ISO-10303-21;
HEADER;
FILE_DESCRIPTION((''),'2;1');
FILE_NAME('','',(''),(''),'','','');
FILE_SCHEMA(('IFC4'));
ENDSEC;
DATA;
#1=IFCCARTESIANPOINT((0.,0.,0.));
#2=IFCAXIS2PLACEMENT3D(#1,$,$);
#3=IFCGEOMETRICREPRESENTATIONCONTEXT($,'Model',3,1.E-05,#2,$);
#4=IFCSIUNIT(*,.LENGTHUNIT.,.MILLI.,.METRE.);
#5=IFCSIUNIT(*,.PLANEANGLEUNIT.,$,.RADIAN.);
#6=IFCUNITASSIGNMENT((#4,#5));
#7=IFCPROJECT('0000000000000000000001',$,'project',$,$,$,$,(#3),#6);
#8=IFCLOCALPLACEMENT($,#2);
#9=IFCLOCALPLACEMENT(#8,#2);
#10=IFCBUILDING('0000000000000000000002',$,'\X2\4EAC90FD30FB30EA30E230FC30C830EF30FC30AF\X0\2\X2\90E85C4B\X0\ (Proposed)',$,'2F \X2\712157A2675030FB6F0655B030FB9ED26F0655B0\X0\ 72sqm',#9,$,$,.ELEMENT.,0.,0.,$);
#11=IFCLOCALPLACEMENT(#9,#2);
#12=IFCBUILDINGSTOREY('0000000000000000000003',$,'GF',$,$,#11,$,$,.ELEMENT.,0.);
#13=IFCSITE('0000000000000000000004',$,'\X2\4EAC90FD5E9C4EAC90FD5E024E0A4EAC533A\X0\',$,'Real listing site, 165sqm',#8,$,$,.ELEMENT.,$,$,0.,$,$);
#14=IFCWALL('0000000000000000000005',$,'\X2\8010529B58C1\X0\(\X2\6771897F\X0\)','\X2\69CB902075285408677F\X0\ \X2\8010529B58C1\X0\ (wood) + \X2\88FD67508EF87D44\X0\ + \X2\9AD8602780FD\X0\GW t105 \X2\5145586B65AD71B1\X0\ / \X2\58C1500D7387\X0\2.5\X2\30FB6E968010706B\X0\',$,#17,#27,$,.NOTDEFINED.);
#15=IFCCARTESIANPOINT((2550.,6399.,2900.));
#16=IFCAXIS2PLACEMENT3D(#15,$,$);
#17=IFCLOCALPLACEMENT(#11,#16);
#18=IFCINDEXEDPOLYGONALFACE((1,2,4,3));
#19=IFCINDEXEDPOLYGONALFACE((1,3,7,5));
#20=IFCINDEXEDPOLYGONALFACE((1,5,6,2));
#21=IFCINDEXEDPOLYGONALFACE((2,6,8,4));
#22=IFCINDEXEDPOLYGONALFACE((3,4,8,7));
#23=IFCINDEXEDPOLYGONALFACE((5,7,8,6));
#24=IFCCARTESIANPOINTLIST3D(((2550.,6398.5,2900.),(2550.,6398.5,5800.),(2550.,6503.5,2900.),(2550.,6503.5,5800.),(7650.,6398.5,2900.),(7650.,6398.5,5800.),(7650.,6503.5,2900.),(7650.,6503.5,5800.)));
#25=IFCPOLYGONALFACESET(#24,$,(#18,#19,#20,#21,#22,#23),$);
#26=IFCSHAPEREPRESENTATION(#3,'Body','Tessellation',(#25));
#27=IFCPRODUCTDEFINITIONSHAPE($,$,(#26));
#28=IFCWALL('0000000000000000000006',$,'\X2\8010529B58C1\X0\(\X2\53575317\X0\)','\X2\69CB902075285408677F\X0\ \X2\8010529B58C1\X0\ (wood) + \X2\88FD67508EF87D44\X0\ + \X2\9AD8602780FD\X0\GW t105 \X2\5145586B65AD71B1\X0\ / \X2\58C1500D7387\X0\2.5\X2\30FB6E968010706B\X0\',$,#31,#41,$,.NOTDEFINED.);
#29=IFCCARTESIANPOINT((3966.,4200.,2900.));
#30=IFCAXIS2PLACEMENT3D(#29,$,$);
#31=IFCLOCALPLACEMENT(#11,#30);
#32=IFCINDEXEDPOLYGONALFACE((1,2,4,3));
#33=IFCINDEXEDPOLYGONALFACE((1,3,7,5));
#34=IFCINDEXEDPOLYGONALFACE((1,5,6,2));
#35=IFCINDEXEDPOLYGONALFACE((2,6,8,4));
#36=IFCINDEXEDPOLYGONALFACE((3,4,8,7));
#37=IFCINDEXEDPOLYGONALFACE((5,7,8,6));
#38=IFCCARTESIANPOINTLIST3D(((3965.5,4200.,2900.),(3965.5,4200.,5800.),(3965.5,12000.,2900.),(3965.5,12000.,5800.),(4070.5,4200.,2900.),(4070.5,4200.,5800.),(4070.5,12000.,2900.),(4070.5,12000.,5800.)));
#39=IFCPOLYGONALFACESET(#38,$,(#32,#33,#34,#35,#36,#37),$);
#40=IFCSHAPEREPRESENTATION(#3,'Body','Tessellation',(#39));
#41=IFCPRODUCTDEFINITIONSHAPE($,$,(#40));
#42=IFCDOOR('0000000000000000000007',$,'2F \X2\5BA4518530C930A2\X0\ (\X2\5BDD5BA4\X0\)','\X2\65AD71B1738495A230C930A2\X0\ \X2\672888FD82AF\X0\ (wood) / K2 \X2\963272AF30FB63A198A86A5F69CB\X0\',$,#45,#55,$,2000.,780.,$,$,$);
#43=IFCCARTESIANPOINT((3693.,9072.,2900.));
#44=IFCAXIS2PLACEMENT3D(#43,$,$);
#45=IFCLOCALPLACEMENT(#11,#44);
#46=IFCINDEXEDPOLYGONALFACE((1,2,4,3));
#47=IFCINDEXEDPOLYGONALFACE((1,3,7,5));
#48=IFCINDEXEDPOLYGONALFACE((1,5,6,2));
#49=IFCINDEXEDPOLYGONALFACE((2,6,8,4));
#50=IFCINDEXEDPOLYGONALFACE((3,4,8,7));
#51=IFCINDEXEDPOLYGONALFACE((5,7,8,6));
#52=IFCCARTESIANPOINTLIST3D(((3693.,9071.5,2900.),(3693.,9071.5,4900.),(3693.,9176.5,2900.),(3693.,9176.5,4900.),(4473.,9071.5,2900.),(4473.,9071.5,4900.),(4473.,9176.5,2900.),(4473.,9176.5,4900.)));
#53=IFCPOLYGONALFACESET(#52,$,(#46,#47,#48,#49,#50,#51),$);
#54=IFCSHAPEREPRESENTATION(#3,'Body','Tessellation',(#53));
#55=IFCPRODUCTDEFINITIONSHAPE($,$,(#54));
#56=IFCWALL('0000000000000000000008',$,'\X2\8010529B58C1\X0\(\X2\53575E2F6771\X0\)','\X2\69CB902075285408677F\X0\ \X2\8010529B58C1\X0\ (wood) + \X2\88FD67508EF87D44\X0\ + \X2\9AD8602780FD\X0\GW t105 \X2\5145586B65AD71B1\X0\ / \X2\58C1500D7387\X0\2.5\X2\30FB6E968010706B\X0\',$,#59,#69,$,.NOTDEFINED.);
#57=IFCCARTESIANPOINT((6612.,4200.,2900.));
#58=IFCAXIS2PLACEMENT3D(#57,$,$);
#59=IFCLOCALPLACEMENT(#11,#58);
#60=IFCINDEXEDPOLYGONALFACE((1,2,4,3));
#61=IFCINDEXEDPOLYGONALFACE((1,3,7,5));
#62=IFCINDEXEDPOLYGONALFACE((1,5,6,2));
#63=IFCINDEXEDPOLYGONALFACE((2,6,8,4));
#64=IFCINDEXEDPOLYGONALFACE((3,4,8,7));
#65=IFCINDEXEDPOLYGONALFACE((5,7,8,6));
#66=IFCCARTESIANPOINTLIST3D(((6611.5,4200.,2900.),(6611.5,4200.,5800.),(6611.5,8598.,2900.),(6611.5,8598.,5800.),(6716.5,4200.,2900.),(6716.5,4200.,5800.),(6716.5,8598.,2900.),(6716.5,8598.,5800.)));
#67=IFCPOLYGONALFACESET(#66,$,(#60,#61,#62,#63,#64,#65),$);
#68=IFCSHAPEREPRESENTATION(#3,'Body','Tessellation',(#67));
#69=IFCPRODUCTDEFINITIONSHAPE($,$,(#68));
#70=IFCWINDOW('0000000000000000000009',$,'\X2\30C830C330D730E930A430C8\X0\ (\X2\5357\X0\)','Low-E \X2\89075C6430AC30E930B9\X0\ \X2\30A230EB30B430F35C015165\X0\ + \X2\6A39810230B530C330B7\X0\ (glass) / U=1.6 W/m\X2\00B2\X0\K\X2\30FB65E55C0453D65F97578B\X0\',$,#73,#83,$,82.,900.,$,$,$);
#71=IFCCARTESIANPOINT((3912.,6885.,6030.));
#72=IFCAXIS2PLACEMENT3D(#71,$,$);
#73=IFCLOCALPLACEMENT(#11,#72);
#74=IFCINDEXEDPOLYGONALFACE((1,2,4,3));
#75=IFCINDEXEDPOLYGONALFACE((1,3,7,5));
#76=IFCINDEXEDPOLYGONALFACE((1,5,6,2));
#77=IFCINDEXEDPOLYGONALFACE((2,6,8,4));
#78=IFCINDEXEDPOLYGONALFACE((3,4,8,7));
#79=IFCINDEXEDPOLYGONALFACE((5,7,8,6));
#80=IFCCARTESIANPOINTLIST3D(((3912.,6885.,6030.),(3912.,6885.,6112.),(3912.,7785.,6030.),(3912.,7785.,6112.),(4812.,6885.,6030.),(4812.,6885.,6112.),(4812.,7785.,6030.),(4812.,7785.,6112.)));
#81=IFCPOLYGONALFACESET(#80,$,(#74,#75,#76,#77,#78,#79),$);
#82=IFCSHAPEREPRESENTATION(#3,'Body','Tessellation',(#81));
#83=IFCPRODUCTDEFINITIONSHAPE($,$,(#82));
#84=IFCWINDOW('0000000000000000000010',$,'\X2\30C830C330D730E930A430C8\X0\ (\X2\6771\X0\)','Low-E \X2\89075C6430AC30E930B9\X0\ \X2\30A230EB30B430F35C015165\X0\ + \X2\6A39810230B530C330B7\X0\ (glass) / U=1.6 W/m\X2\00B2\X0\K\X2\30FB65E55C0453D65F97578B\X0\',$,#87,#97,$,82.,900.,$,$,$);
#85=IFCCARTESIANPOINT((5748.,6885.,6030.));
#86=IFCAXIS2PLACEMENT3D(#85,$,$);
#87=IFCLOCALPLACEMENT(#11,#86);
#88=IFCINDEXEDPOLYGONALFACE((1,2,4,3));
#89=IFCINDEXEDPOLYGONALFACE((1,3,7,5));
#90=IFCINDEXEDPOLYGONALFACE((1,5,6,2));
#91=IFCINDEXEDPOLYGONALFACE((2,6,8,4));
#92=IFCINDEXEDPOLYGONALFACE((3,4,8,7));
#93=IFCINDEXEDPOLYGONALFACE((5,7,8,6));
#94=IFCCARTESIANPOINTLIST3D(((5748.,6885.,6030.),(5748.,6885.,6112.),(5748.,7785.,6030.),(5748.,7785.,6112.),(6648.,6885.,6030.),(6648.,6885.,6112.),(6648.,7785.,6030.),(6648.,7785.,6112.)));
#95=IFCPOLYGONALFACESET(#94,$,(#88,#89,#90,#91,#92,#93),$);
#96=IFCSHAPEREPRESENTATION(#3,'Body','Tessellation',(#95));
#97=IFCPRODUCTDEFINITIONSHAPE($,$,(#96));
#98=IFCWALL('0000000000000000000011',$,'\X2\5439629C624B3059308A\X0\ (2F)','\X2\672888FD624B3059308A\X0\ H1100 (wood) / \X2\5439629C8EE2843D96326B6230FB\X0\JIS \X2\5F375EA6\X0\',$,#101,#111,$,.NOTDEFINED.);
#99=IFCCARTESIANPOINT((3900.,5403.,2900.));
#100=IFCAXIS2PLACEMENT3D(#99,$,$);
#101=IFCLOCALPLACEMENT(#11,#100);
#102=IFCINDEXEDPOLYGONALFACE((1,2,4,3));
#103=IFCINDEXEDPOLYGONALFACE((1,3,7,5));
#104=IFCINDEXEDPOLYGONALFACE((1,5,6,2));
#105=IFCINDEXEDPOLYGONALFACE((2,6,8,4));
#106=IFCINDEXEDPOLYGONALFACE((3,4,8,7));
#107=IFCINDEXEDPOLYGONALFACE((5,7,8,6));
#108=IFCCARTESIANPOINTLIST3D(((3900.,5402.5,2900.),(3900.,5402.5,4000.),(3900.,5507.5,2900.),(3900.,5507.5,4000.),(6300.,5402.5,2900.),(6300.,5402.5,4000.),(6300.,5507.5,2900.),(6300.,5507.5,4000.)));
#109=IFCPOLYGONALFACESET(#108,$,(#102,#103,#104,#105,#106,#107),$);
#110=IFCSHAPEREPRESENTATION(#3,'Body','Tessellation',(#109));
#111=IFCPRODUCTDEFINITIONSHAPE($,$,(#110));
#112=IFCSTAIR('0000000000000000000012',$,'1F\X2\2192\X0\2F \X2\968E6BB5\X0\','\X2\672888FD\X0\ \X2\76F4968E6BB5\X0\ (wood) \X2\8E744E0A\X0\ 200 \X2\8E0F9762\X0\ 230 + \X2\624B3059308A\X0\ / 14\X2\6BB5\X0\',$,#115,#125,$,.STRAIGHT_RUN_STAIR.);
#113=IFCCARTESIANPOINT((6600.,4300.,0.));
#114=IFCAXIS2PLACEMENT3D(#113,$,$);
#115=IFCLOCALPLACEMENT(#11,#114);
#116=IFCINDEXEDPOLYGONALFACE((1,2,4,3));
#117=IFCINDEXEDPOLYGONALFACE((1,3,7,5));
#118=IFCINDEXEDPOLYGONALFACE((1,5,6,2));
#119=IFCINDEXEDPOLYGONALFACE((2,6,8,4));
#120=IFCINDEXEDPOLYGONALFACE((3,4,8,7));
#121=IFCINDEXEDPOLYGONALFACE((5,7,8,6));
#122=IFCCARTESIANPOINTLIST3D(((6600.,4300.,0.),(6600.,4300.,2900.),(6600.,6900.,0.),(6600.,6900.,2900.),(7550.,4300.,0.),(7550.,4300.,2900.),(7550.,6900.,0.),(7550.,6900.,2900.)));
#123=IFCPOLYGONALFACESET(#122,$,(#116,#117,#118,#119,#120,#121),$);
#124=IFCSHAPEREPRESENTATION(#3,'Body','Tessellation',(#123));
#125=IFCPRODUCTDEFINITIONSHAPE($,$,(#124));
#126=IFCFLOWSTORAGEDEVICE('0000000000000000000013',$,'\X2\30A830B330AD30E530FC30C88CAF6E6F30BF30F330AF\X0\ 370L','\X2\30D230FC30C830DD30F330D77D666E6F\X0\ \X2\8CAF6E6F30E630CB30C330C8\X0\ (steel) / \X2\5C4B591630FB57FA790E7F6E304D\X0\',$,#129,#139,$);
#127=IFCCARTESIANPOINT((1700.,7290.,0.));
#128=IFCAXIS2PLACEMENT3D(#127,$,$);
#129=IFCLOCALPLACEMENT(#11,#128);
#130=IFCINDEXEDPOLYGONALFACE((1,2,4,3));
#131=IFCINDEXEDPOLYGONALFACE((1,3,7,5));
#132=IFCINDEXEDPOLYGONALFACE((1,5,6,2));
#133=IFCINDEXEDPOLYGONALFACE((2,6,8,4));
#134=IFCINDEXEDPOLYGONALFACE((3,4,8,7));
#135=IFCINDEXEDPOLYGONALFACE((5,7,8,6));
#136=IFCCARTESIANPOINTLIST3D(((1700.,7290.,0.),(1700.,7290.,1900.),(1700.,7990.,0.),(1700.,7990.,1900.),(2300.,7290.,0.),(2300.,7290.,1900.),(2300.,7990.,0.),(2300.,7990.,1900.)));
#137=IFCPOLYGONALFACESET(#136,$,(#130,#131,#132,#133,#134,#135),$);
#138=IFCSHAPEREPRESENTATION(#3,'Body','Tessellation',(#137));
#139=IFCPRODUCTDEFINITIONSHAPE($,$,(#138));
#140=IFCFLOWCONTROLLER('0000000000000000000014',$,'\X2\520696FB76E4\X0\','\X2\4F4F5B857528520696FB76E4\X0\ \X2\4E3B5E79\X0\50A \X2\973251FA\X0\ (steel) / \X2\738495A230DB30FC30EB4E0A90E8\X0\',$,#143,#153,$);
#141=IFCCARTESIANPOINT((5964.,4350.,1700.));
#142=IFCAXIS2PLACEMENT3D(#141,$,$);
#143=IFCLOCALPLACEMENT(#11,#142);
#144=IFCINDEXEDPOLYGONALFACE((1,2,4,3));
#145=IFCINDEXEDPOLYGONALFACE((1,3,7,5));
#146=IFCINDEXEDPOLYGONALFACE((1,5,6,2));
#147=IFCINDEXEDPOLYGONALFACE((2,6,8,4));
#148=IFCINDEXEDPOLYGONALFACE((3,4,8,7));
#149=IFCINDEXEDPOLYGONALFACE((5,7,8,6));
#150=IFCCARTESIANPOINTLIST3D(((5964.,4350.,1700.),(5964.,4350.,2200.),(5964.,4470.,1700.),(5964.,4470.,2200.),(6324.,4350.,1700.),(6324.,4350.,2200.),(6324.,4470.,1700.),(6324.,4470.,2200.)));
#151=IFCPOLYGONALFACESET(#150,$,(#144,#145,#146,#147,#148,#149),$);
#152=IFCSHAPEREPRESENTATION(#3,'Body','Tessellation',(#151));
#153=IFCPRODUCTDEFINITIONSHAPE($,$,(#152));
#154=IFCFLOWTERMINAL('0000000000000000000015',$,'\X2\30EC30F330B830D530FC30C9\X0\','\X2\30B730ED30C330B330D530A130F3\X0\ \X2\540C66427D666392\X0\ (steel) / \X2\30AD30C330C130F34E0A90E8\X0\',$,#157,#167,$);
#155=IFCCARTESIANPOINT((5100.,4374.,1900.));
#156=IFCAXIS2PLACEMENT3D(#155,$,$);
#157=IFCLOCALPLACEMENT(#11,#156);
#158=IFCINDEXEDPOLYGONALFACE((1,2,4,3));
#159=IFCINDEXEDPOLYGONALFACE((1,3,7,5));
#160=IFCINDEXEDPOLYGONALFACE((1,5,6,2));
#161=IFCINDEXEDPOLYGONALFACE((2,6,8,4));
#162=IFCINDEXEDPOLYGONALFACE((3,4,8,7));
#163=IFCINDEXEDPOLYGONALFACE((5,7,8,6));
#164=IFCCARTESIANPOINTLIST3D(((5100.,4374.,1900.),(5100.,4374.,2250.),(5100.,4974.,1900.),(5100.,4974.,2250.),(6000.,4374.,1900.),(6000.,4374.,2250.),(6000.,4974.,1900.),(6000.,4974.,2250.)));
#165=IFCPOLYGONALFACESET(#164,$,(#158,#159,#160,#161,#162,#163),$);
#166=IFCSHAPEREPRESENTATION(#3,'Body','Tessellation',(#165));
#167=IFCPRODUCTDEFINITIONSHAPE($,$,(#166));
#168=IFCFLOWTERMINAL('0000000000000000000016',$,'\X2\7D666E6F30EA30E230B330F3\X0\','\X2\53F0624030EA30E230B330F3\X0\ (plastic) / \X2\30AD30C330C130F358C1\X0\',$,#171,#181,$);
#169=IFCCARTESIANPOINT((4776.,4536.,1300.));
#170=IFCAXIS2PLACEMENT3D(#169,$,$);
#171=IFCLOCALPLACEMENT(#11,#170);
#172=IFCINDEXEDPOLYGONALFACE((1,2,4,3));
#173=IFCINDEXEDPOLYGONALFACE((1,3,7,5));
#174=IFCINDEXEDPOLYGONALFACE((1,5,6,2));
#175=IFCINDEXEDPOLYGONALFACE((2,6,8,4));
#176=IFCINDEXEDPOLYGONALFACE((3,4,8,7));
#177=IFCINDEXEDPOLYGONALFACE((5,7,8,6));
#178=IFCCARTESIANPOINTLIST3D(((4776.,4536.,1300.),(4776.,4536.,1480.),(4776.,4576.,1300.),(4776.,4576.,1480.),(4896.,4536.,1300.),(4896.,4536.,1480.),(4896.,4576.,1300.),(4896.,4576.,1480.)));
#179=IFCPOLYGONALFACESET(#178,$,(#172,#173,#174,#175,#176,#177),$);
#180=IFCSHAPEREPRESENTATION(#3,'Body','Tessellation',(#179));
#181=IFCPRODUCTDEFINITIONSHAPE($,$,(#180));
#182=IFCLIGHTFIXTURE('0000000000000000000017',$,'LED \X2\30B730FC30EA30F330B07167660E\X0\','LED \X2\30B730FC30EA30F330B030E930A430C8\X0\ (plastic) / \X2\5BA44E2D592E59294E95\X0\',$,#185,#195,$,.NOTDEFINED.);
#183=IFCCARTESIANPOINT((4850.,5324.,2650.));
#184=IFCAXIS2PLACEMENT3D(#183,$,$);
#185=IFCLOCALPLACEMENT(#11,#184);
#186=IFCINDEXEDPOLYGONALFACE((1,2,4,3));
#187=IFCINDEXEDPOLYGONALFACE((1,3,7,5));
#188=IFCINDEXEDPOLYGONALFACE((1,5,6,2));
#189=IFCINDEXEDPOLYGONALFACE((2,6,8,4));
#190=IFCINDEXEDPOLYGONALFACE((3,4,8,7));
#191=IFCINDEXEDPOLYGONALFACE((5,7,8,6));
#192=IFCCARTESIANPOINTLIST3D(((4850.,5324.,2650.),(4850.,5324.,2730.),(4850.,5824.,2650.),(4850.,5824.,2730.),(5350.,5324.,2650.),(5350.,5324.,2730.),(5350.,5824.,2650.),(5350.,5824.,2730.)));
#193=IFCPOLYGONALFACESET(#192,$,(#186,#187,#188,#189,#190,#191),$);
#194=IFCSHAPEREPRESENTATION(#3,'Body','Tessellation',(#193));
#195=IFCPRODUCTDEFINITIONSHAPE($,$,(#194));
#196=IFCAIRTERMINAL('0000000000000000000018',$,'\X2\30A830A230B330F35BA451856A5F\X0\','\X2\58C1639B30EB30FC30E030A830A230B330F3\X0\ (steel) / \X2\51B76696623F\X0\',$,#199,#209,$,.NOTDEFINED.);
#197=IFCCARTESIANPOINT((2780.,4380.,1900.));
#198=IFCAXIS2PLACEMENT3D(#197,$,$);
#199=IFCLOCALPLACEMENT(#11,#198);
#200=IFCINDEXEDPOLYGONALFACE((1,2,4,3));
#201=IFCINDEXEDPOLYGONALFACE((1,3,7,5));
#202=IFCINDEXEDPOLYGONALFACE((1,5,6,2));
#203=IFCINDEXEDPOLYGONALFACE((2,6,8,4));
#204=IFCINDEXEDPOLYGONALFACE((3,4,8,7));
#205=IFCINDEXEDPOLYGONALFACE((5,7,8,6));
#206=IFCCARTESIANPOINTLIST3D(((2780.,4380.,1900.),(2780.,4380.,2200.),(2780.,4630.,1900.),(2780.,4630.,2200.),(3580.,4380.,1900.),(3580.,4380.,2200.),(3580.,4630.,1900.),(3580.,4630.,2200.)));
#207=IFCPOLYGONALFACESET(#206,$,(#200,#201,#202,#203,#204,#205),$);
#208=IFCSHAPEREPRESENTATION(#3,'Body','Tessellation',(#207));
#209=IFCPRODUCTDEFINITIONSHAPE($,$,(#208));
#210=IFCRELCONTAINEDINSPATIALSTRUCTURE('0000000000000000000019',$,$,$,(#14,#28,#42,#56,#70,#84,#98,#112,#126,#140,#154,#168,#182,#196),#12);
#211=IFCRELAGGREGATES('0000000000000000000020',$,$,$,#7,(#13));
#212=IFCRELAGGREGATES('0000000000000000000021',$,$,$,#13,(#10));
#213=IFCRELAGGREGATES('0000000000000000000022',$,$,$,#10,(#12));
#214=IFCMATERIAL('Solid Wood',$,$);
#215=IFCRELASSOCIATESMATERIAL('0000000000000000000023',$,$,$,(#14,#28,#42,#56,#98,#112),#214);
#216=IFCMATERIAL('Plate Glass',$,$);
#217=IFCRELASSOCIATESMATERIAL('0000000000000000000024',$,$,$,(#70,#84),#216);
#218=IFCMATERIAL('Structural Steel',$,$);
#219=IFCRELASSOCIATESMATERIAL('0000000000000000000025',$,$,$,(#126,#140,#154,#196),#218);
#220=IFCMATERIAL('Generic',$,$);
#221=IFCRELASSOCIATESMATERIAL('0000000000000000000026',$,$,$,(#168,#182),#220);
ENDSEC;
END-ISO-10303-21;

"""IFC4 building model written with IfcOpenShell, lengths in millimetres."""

from ifc_helpers import new_model, si_unit, frame, frame_2d, origin, place, context, project, spatial, rectangle, extrude, material, element, fill, save


model = new_model("IFC4")

# Units and contexts
model_context = context("Model", 3, precision=1e-05, world=origin())
ifc_project = project(units=[si_unit("LENGTHUNIT", "METRE", prefix="MILLI"), si_unit("PLANEANGLEUNIT", "RADIAN")], contexts=[model_context])

# Site, building, storey
site_placement = place(None, origin())
site = spatial("IfcSite", under=ifc_project, at=site_placement, Name="京都府京都市上京区", ObjectType="Real listing site, 165sqm", CompositionType="ELEMENT", RefElevation=0.0)
building_placement = place(site_placement, origin())
building = spatial("IfcBuilding", under=site, at=building_placement, Name="京都・リモートワーク2部屋 (Proposed)", ObjectType="2F 無垢材・漆喰・黒漆喰 72sqm", CompositionType="ELEMENT", ElevationOfRefHeight=0.0, ElevationOfTerrain=0.0)
storey_placement = place(building_placement, origin())
storey = spatial("IfcBuildingStorey", under=building, at=storey_placement, Name="GF", CompositionType="ELEMENT", Elevation=0.0)

# Shared definitions
ifc_material_1 = material(Name="Solid Wood")

# Wall
wall_1_placement = place(storey_placement, frame((2550.0, 6399.0, 2900.0)))
element("IfcWall", 1, at=wall_1_placement, inside=storey, material=ifc_material_1, Name="耐力壁(東西)", Description="構造用合板 耐力壁 (wood) + 製材軸組 + 高性能GW t105 充填断熱 / 壁倍率2.5・準耐火", PredefinedType="NOTDEFINED", context=model_context, shape_type="SweptSolid", body=[
    extrude(rectangle(XDim=5100.0, YDim=105.0, at=frame_2d((2550.0, 52.0))), frame((2550.0, 6399.0, 2900.0)), (0.0, 0.0, 1.0), 2900.0),
])

# Wall, opening, door
wall_2_placement = place(storey_placement, frame((3966.0, 4200.0, 2900.0)))
wall_2 = element("IfcWall", 2, at=wall_2_placement, inside=storey, material=ifc_material_1, Name="耐力壁(南北)", Description="構造用合板 耐力壁 (wood) + 製材軸組 + 高性能GW t105 充填断熱 / 壁倍率2.5・準耐火", PredefinedType="NOTDEFINED", context=model_context, shape_type="SweptSolid", body=[
    extrude(rectangle(XDim=105.0, YDim=7800.0, at=frame_2d((52.0, 3900.0))), frame((3966.0, 4200.0, 2900.0)), (0.0, 0.0, 1.0), 2900.0),
])
opening_placement = place(storey_placement, frame((3693.0, 9072.0, 2900.0)))
opening = element("IfcOpeningElement", 3, at=opening_placement, cuts=wall_2, PredefinedType="NOTDEFINED", context=model_context, shape_type="SweptSolid", body=[
    extrude(rectangle(XDim=780.0, YDim=105.0, at=frame_2d((390.0, 52.0))), frame((3693.0, 9072.0, 2900.0)), (0.0, 0.0, 1.0), 2000.0),
])
door_placement = place(storey_placement, frame((3693.0, 9072.0, 2900.0)))
door = element("IfcDoor", 4, at=door_placement, inside=storey, material=ifc_material_1, Name="2F 室内ドア (寝室)", Description="断熱玄関ドア 木製芯 (wood) / K2 防犯・採風機構", OverallHeight=2000.0, OverallWidth=780.0, context=model_context, shape_type="SweptSolid", body=[
    extrude(rectangle(XDim=780.0, YDim=105.0, at=frame_2d((390.0, 52.0))), frame((3693.0, 9072.0, 2900.0)), (0.0, 0.0, 1.0), 2000.0),
])
fill(opening, door)

# Wall
wall_3_placement = place(storey_placement, frame((6612.0, 4200.0, 2900.0)))
element("IfcWall", 5, at=wall_3_placement, inside=storey, material=ifc_material_1, Name="耐力壁(南帯東)", Description="構造用合板 耐力壁 (wood) + 製材軸組 + 高性能GW t105 充填断熱 / 壁倍率2.5・準耐火", PredefinedType="NOTDEFINED", context=model_context, shape_type="SweptSolid", body=[
    extrude(rectangle(XDim=105.0, YDim=4398.0, at=frame_2d((52.0, 2199.0))), frame((6612.0, 4200.0, 2900.0)), (0.0, 0.0, 1.0), 2900.0),
])

# Windows
ifc_material_2 = material(Name="Plate Glass")
window_1_placement = place(storey_placement, frame((3912.0, 6885.0, 6030.0)))
element("IfcWindow", 6, at=window_1_placement, inside=storey, material=ifc_material_2, Name="トップライト (南)", Description="Low-E 複層ガラス アルゴン封入 + 樹脂サッシ (glass) / U=1.6 W/m²K・日射取得型", OverallHeight=82.0, OverallWidth=900.0, context=model_context, shape_type="SweptSolid", body=[
    extrude(rectangle(XDim=900.0, YDim=900.0, at=frame_2d((450.0, 450.0))), frame((3912.0, 6885.0, 6030.0)), (0.0, 0.0, 1.0), 82.0),
])
window_2_placement = place(storey_placement, frame((5748.0, 6885.0, 6030.0)))
element("IfcWindow", 7, at=window_2_placement, inside=storey, material=ifc_material_2, Name="トップライト (東)", Description="Low-E 複層ガラス アルゴン封入 + 樹脂サッシ (glass) / U=1.6 W/m²K・日射取得型", OverallHeight=82.0, OverallWidth=900.0, context=model_context, shape_type="SweptSolid", body=[
    extrude(rectangle(XDim=900.0, YDim=900.0, at=frame_2d((450.0, 450.0))), frame((5748.0, 6885.0, 6030.0)), (0.0, 0.0, 1.0), 82.0),
])

# Wall
wall_4_placement = place(storey_placement, frame((3900.0, 5403.0, 2900.0)))
element("IfcWall", 8, at=wall_4_placement, inside=storey, material=ifc_material_1, Name="吹抜手すり (2F)", Description="木製手すり H1100 (wood) / 吹抜転落防止・JIS 強度", PredefinedType="NOTDEFINED", context=model_context, shape_type="SweptSolid", body=[
    extrude(rectangle(XDim=2400.0, YDim=105.0, at=frame_2d((1200.0, 52.0))), frame((3900.0, 5403.0, 2900.0)), (0.0, 0.0, 1.0), 1100.0),
])

# Stair
stair_placement = place(storey_placement, frame((6600.0, 4300.0, 0.0)))
element("IfcStair", 9, at=stair_placement, inside=storey, material=ifc_material_1, Name="1F→2F 階段", Description="木製 直階段 (wood) 蹴上 200 踏面 230 + 手すり / 14段", PredefinedType="STRAIGHT_RUN_STAIR", context=model_context, shape_type="SweptSolid", body=[
    extrude(rectangle(XDim=950.0, YDim=2600.0, at=frame_2d((475.0, 1300.0))), frame((6600.0, 4300.0, 0.0)), (0.0, 0.0, 1.0), 2900.0),
])

# Flow storage device
ifc_material_3 = material(Name="Structural Steel")
flow_storage_device_placement = place(storey_placement, frame((1700.0, 7290.0, 0.0)))
element("IfcFlowStorageDevice", 10, at=flow_storage_device_placement, inside=storey, material=ifc_material_3, Name="エコキュート貯湯タンク 370L", Description="ヒートポンプ給湯 貯湯ユニット (steel) / 屋外・基礎置き", context=model_context, shape_type="SweptSolid", body=[
    extrude(rectangle(XDim=600.0, YDim=700.0, at=frame_2d((300.0, 350.0))), frame((1700.0, 7290.0, 0.0)), (0.0, 0.0, 1.0), 1900.0),
])

# Flow controller
flow_controller_placement = place(storey_placement, frame((5964.0, 4350.0, 1700.0)))
element("IfcFlowController", 11, at=flow_controller_placement, inside=storey, material=ifc_material_3, Name="分電盤", Description="住宅用分電盤 主幹50A 露出 (steel) / 玄関ホール上部", context=model_context, shape_type="SweptSolid", body=[
    extrude(rectangle(XDim=360.0, YDim=120.0, at=frame_2d((180.0, 60.0))), frame((5964.0, 4350.0, 1700.0)), (0.0, 0.0, 1.0), 500.0),
])

# Flow terminals
flow_terminal_1_placement = place(storey_placement, frame((5100.0, 4374.0, 1900.0)))
element("IfcFlowTerminal", 12, at=flow_terminal_1_placement, inside=storey, material=ifc_material_3, Name="レンジフード", Description="シロッコファン 同時給排 (steel) / キッチン上部", context=model_context, shape_type="SweptSolid", body=[
    extrude(rectangle(XDim=900.0, YDim=600.0, at=frame_2d((450.0, 300.0))), frame((5100.0, 4374.0, 1900.0)), (0.0, 0.0, 1.0), 350.0),
])
ifc_material_4 = material(Name="Generic")
flow_terminal_2_placement = place(storey_placement, frame((4776.0, 4536.0, 1300.0)))
element("IfcFlowTerminal", 13, at=flow_terminal_2_placement, inside=storey, material=ifc_material_4, Name="給湯リモコン", Description="台所リモコン (plastic) / キッチン壁", context=model_context, shape_type="SweptSolid", body=[
    extrude(rectangle(XDim=120.0, YDim=40.0, at=frame_2d((60.0, 20.0))), frame((4776.0, 4536.0, 1300.0)), (0.0, 0.0, 1.0), 180.0),
])

# Light fixture
light_fixture_1_placement = place(storey_placement, frame((4850.0, 5324.0, 2650.0)))
element("IfcLightFixture", 14, at=light_fixture_1_placement, inside=storey, material=ifc_material_4, Name="LED シーリング照明", Description="LED シーリングライト (plastic) / 室中央天井", PredefinedType="NOTDEFINED", context=model_context, shape_type="SweptSolid", body=[
    extrude(rectangle(XDim=500.0, YDim=500.0, at=frame_2d((250.0, 250.0))), frame((4850.0, 5324.0, 2650.0)), (0.0, 0.0, 1.0), 80.0),
])

# Air terminal
air_terminal_1_placement = place(storey_placement, frame((2780.0, 4380.0, 1900.0)))
element("IfcAirTerminal", 15, at=air_terminal_1_placement, inside=storey, material=ifc_material_3, Name="エアコン室内機", Description="壁掛ルームエアコン (steel) / 冷暖房", PredefinedType="NOTDEFINED", context=model_context, shape_type="SweptSolid", body=[
    extrude(rectangle(XDim=800.0, YDim=250.0, at=frame_2d((400.0, 125.0))), frame((2780.0, 4380.0, 1900.0)), (0.0, 0.0, 1.0), 300.0),
])

save(model, "model.ifc")
